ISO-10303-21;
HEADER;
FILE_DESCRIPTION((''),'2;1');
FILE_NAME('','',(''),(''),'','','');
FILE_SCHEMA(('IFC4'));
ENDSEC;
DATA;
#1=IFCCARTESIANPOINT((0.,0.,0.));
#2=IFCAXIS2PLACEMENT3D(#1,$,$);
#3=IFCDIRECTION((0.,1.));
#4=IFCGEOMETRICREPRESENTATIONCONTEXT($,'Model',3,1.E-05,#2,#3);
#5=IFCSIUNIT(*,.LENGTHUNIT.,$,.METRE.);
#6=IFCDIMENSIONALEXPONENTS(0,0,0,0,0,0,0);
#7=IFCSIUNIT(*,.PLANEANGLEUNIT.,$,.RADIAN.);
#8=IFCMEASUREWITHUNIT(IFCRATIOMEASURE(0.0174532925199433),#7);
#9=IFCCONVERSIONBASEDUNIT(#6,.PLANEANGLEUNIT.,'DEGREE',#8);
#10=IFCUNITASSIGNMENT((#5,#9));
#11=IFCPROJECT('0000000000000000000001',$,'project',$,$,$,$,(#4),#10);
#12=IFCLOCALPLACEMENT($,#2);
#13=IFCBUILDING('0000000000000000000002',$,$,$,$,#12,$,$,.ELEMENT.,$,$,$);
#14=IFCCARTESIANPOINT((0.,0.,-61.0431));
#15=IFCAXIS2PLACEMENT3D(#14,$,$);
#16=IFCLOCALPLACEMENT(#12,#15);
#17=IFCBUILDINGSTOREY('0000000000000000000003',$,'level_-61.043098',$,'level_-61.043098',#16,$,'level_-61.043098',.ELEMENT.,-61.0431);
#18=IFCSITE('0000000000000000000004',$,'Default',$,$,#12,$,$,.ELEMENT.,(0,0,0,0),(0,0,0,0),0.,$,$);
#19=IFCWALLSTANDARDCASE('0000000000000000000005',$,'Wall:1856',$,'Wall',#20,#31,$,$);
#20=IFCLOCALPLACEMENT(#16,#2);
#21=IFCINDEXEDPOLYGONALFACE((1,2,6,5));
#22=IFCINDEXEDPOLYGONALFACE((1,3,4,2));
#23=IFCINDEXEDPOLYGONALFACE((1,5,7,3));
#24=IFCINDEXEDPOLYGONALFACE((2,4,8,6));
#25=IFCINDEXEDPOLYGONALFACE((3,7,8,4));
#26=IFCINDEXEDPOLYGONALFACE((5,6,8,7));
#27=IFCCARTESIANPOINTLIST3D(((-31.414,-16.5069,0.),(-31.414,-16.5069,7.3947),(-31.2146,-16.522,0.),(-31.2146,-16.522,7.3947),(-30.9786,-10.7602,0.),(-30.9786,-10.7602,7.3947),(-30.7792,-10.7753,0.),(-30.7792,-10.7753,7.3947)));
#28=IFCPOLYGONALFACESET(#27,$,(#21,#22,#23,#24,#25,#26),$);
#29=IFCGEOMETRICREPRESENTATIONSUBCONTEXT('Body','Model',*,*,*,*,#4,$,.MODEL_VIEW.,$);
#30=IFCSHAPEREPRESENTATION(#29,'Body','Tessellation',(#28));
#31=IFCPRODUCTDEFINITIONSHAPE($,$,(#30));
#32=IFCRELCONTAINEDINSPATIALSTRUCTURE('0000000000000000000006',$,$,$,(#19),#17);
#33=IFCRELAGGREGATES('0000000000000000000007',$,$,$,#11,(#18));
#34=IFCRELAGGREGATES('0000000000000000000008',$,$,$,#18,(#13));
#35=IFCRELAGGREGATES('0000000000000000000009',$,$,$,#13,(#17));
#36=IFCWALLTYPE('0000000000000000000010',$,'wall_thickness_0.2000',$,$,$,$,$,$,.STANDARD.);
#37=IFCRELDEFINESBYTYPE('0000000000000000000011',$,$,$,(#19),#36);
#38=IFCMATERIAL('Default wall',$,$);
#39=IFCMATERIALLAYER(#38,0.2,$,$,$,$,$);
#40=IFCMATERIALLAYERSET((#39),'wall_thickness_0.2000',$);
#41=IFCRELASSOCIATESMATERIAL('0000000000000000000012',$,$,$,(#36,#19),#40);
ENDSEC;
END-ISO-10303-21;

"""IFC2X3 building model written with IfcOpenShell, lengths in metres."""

from ifc_helpers import new_model, entity, si_unit, converted_unit, direction, frame, origin, place, context, subcontext, project, spatial, polyline, outline, extrude, material, layer, layer_set, layer_usage, type_object, element, save


model = new_model("IFC2X3")

# Units and contexts
model_context = context("Model", 3, precision=1e-05, world=origin(), true_north=direction((0.0, 1.0)))
body_context = subcontext(model_context, "Body", "Model", "MODEL_VIEW")
ifc_project = project(units=[si_unit("LENGTHUNIT", "METRE"), converted_unit("PLANEANGLEUNIT", "DEGREE", entity("IfcRatioMeasure", 0.0174532925199433), si_unit("PLANEANGLEUNIT", "RADIAN"), dimensions=[0, 0, 0, 0, 0, 0, 0])], contexts=[model_context])

# Site, building, storey
placement_1 = place(None, origin())
site = spatial("IfcSite", under=ifc_project, at=placement_1, Name="Default", CompositionType="ELEMENT", RefLatitude=(0, 0, 0, 0), RefLongitude=(0, 0, 0, 0), RefElevation=0.0)
building = spatial("IfcBuilding", under=site, at=placement_1, CompositionType="ELEMENT")
storey_placement = place(placement_1, frame((0.0, 0.0, -61.0431)))
storey = spatial("IfcBuildingStorey", under=building, at=storey_placement, Name="level_-61.043098", ObjectType="level_-61.043098", LongName="level_-61.043098", CompositionType="ELEMENT", Elevation=-61.0431)

# Shared definitions
ifc_material_1 = material(Name="Default wall")
ifc_layer = layer(ifc_material_1, 0.2)
ifc_layer_set = layer_set([ifc_layer], Name="wall_thickness_0.2000")
ifc_layer_usage = layer_usage(ifc_layer_set, "AXIS2", "POSITIVE", -0.1)
wall_type = type_object("IfcWallType", Name="wall_thickness_0.2000", PredefinedType="STANDARD", material=ifc_layer_set)

# Wall
wall_1_placement = place(storey_placement, frame((-30.8789, -10.7678, 0.0), z_axis=(0.0, 0.0, 1.0), x_axis=(-0.075547, -0.997142, 0.0)))
element("IfcWallStandardCase", 1, at=wall_1_placement, inside=storey, type_object=wall_type, material=ifc_layer_usage, Name="Wall:1856", ObjectType="Wall", context=body_context, shape_type="SweptSolid", body=[
    extrude(outline(polyline([(5.7632, -0.1), (5.7632, 0.1), (0.0, 0.1), (0.0, -0.1), (5.7632, -0.1)])), origin(), (0.0, 0.0, 1.0), 7.3947),
])

save(model, "model.ifc")
